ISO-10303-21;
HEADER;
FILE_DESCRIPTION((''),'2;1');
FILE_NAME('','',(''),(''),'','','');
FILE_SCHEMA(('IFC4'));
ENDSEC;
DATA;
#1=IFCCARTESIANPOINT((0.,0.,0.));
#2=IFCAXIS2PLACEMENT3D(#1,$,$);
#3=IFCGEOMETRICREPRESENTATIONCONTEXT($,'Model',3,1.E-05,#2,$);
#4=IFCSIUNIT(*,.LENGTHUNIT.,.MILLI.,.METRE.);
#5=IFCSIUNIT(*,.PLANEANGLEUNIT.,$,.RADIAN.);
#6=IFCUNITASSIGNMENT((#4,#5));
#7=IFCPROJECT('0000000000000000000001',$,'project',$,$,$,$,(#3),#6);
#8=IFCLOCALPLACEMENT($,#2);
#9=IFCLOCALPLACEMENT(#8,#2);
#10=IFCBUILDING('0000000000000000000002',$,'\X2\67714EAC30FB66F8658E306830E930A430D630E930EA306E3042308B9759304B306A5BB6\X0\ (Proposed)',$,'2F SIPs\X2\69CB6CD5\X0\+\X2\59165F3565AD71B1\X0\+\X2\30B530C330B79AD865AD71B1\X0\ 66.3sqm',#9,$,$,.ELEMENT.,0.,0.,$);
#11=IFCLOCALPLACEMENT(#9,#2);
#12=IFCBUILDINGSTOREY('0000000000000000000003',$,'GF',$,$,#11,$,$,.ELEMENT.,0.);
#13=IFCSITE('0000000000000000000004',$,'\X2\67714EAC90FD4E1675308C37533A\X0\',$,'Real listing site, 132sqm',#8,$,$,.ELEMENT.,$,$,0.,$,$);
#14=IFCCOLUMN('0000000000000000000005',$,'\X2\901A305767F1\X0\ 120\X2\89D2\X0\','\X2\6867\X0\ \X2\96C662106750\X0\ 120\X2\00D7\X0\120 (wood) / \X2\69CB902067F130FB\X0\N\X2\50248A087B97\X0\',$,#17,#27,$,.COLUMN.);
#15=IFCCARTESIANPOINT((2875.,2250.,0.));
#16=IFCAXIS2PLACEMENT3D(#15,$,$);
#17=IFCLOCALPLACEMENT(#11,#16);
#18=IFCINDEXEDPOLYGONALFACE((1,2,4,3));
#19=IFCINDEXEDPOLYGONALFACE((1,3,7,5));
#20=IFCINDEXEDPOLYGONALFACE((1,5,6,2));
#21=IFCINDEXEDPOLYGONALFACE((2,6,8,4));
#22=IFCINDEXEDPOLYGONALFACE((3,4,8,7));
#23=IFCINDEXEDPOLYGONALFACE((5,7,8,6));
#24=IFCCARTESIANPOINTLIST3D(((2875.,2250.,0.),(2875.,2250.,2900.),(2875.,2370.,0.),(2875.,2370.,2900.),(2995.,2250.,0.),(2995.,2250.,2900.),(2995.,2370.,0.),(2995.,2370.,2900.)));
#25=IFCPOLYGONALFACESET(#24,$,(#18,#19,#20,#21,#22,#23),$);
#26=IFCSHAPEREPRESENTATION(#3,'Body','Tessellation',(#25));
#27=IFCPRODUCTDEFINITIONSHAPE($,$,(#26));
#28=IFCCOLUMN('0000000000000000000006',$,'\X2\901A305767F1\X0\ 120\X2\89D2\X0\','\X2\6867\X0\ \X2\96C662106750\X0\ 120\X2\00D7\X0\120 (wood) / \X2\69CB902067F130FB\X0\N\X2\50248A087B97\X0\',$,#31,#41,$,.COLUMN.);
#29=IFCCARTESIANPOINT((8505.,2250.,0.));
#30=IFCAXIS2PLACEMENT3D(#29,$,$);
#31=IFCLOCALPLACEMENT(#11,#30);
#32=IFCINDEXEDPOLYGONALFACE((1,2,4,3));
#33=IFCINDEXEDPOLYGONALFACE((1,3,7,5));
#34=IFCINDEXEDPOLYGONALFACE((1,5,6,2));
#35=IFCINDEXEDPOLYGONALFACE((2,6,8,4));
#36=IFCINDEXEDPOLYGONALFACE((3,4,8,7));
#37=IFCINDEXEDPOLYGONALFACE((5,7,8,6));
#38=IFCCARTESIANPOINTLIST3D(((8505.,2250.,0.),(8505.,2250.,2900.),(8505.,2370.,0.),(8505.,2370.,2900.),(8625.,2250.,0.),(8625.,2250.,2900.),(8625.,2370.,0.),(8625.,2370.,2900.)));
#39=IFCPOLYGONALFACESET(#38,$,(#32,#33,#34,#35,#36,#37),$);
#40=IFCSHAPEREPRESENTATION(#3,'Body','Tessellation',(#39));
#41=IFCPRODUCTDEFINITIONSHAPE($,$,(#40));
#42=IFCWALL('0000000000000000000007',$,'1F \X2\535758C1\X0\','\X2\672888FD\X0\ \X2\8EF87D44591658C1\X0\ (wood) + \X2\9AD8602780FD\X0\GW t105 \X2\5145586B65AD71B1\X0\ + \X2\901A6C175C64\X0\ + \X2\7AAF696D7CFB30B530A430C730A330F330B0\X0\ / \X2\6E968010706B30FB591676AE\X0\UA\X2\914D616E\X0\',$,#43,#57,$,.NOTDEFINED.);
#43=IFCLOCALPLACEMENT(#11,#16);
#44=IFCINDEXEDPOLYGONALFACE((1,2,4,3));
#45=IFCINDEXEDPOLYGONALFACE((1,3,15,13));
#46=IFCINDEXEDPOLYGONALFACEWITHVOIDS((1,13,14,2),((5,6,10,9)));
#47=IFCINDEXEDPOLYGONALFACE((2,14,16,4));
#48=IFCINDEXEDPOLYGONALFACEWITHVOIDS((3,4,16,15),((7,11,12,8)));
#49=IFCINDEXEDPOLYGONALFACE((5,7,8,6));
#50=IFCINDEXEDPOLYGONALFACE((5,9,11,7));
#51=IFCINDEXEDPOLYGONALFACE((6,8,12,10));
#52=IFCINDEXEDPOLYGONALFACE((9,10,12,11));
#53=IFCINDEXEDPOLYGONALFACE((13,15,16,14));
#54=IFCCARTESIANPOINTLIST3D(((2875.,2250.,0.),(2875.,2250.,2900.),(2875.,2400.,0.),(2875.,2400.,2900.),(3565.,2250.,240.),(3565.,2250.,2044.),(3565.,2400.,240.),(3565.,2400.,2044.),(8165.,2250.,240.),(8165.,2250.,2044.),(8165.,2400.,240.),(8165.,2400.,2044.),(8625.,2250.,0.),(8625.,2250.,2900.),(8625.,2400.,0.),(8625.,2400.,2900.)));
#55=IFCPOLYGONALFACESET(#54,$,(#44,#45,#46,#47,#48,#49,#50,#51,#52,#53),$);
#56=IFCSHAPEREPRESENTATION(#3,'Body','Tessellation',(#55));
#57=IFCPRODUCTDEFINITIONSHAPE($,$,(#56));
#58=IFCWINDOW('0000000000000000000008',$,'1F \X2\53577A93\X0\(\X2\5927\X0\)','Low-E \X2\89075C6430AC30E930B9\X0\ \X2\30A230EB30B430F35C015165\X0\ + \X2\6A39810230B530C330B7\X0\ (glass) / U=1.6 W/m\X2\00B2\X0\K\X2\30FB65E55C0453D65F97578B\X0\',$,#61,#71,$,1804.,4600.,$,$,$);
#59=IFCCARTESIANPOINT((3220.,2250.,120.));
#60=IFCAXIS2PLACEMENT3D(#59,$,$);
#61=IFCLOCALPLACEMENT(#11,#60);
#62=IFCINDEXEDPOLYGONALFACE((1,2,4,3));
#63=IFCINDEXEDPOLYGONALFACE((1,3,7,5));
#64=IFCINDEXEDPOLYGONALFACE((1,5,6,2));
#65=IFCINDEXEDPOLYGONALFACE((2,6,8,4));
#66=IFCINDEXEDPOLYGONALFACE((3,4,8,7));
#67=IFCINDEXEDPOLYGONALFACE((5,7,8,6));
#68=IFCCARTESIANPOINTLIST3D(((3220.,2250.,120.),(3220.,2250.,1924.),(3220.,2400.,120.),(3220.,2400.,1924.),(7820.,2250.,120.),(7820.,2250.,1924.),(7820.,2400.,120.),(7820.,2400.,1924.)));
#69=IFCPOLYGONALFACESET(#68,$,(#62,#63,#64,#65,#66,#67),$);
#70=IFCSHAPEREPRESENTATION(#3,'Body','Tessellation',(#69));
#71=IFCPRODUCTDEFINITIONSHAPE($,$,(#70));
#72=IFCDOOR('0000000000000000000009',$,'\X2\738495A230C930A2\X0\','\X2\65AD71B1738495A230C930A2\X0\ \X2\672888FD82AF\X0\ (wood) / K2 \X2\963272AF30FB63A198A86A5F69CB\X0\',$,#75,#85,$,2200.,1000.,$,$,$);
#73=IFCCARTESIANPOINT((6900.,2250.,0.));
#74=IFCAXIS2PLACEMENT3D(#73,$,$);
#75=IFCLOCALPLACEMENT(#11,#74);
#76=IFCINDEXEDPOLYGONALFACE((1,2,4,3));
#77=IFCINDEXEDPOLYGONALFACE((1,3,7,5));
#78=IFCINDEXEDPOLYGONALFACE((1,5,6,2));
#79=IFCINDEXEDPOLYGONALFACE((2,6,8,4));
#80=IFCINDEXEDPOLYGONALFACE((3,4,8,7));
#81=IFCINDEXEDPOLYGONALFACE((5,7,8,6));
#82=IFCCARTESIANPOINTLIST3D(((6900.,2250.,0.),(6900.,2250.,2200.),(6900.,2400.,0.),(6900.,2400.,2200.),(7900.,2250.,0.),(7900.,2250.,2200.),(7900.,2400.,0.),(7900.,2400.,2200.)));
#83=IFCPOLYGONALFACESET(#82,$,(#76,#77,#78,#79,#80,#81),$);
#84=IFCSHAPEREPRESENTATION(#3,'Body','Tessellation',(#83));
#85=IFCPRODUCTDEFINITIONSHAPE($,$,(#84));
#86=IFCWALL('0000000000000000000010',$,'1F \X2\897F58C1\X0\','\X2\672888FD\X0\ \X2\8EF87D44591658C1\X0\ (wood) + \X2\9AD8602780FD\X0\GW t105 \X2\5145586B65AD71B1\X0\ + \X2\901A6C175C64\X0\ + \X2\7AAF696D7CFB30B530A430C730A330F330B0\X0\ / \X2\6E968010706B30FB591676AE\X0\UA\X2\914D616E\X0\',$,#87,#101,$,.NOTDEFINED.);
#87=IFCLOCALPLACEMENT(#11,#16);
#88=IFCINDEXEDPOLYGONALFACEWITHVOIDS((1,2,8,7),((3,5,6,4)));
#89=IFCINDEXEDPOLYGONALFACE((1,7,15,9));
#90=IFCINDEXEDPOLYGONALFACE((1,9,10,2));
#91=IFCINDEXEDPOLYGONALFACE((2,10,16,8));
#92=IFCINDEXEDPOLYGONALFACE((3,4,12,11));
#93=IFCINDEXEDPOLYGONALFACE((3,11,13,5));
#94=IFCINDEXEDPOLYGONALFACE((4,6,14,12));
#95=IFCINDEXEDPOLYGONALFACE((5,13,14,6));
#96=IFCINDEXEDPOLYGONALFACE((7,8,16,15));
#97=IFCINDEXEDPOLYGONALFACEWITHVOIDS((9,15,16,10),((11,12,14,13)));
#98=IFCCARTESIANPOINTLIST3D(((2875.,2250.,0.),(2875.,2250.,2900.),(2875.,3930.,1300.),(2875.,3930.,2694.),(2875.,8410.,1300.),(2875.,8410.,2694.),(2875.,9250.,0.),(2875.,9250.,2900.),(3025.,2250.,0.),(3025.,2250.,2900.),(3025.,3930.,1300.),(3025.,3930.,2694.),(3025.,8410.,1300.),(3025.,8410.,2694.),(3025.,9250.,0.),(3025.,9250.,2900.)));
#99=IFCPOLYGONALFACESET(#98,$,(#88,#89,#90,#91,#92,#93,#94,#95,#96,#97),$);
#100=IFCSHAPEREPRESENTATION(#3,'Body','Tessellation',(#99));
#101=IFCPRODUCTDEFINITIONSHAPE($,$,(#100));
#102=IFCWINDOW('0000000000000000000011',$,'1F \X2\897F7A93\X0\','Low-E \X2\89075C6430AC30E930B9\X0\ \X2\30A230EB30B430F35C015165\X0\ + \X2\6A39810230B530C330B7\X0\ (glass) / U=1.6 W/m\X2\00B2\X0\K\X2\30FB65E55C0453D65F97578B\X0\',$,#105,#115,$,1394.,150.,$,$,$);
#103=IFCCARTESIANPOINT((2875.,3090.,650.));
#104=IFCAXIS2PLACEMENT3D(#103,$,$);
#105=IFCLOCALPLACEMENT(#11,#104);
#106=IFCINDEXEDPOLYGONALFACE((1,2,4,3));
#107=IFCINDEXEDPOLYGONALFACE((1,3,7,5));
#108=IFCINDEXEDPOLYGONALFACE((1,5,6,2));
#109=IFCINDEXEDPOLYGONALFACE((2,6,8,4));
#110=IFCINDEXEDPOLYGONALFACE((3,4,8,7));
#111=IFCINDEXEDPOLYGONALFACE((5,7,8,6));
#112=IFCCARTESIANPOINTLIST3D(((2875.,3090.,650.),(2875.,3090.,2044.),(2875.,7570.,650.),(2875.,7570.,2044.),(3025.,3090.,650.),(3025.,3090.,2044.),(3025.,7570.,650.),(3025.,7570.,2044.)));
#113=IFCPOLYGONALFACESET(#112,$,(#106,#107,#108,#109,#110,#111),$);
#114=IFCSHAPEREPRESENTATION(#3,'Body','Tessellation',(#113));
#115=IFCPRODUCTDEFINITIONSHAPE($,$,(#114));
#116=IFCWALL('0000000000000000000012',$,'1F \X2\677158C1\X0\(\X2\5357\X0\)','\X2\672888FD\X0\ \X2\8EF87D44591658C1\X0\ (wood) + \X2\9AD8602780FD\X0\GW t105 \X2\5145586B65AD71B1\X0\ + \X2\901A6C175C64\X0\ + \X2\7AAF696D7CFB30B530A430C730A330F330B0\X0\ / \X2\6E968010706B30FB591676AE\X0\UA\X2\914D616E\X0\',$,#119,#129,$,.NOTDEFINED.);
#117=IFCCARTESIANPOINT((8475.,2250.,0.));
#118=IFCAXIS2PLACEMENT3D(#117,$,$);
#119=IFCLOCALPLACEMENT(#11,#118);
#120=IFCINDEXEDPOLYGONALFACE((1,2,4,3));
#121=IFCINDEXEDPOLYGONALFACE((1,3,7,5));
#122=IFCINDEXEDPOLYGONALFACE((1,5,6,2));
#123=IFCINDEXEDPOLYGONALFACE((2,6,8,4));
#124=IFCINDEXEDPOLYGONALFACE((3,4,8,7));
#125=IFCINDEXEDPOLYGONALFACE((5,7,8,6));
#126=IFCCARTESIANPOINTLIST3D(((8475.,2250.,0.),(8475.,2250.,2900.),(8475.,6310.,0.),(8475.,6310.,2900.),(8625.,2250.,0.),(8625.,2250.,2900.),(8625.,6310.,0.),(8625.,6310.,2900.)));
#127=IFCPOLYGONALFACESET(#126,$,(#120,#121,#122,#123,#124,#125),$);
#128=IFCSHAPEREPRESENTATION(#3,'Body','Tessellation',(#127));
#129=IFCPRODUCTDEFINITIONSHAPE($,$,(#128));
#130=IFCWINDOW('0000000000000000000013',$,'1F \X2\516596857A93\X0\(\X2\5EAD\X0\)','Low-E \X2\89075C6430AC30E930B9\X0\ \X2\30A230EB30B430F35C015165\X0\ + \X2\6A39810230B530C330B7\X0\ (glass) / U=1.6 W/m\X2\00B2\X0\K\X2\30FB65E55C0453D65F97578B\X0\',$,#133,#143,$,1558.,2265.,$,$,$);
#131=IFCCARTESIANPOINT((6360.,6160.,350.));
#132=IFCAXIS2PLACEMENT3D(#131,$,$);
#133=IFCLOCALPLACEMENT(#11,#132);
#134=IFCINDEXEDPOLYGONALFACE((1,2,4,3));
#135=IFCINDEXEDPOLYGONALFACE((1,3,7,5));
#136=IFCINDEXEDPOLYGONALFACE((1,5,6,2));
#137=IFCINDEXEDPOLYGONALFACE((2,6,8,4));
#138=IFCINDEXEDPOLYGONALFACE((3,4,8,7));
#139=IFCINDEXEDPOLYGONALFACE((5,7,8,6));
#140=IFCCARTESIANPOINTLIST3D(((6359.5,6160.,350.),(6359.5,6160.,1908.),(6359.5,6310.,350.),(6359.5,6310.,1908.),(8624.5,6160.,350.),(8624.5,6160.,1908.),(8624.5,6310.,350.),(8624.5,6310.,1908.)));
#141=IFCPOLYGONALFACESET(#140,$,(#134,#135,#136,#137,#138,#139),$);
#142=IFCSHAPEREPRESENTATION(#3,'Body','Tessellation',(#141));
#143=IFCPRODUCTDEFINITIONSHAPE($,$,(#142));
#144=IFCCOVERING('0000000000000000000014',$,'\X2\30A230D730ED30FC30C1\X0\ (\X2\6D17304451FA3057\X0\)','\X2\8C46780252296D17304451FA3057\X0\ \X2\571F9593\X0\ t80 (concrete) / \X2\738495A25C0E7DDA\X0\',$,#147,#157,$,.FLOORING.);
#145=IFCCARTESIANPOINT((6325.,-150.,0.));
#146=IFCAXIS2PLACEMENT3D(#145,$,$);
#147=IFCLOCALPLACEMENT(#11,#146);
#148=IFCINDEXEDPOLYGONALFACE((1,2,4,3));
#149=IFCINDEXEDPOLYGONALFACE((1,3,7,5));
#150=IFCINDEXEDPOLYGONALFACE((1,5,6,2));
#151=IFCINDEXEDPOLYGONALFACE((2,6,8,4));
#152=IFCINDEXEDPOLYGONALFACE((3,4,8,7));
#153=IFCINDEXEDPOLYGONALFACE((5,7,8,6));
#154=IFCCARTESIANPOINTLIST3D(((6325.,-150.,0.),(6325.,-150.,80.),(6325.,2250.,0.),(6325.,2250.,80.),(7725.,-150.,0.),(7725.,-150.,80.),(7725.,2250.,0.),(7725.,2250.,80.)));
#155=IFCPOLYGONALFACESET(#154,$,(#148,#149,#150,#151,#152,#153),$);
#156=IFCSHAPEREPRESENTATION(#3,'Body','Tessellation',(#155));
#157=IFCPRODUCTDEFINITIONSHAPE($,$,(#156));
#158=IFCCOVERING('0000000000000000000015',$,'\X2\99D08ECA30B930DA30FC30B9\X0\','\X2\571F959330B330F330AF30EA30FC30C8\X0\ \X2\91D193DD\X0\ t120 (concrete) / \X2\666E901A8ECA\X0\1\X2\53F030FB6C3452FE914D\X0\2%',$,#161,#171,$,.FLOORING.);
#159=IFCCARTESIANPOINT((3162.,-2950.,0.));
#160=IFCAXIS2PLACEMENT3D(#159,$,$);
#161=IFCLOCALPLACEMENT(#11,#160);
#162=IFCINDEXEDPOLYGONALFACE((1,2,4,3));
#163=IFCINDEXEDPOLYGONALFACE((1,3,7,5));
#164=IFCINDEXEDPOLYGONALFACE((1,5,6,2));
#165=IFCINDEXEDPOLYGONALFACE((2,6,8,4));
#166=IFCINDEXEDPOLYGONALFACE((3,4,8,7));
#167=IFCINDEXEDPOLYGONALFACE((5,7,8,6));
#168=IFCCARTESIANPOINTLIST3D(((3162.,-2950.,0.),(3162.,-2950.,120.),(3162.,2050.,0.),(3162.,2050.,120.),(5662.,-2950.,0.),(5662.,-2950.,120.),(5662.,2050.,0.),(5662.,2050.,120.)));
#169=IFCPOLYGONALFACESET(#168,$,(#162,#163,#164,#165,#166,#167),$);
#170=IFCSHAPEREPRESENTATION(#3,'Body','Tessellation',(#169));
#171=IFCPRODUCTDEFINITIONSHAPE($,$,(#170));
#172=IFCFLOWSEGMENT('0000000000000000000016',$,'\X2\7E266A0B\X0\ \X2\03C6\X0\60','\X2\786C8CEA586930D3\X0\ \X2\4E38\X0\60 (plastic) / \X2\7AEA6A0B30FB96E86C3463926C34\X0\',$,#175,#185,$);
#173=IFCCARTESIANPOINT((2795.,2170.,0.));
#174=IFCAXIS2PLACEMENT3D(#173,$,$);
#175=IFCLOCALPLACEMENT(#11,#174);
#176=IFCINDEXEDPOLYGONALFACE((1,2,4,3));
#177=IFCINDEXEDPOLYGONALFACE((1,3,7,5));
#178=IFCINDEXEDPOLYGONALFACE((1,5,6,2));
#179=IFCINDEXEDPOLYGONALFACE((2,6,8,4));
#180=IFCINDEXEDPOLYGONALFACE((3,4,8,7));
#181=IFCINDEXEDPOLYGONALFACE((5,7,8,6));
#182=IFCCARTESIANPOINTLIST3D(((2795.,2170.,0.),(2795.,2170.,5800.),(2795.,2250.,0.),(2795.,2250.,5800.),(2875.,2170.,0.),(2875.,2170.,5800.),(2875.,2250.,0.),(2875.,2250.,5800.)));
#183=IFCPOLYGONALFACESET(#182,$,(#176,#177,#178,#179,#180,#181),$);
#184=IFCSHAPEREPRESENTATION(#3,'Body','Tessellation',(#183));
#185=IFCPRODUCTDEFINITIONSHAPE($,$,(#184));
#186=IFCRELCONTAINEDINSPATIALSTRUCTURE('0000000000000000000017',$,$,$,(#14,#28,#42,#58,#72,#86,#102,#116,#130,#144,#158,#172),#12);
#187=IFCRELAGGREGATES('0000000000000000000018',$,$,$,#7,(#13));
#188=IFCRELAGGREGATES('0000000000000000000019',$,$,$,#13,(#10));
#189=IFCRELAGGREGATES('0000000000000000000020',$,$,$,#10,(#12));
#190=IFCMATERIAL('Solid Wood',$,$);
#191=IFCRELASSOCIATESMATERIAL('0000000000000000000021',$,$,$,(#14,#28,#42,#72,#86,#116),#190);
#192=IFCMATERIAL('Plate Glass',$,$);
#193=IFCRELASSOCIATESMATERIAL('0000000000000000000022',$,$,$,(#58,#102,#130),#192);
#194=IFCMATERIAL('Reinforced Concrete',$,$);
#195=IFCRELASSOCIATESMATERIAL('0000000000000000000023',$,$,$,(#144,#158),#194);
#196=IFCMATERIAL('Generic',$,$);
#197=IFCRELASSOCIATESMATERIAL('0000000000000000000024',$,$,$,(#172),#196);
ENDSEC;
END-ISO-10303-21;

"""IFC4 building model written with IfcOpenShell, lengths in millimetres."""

from ifc_helpers import new_model, si_unit, frame, frame_2d, origin, place, context, project, spatial, rectangle, extrude, material, element, fill, save


model = new_model("IFC4")

# Units and contexts
model_context = context("Model", 3, precision=1e-05, world=origin())
ifc_project = project(units=[si_unit("LENGTHUNIT", "METRE", prefix="MILLI"), si_unit("PLANEANGLEUNIT", "RADIAN")], contexts=[model_context])

# Site, building, storey
site_placement = place(None, origin())
site = spatial("IfcSite", under=ifc_project, at=site_placement, Name="東京都世田谷区", ObjectType="Real listing site, 132sqm", CompositionType="ELEMENT", RefElevation=0.0)
building_placement = place(site_placement, origin())
building = spatial("IfcBuilding", under=site, at=building_placement, Name="東京・書斎とライブラリのある静かな家 (Proposed)", ObjectType="2F SIPs構法+外張断熱+サッシ高断熱 66.3sqm", CompositionType="ELEMENT", ElevationOfRefHeight=0.0, ElevationOfTerrain=0.0)
storey_placement = place(building_placement, origin())
storey = spatial("IfcBuildingStorey", under=building, at=storey_placement, Name="GF", CompositionType="ELEMENT", Elevation=0.0)

# Columns
ifc_material_1 = material(Name="Solid Wood")
column_1_placement = place(storey_placement, frame((2875.0, 2250.0, 0.0)))
element("IfcColumn", 1, at=column_1_placement, inside=storey, material=ifc_material_1, Name="通し柱 120角", Description="桧 集成材 120×120 (wood) / 構造柱・N値計算", PredefinedType="COLUMN", context=model_context, shape_type="SweptSolid", body=[
    extrude(rectangle(XDim=120.0, YDim=120.0, at=frame_2d((60.0, 60.0))), frame((2875.0, 2250.0, 0.0)), (0.0, 0.0, 1.0), 2900.0),
])
column_2_placement = place(storey_placement, frame((8505.0, 2250.0, 0.0)))
element("IfcColumn", 2, at=column_2_placement, inside=storey, material=ifc_material_1, Name="通し柱 120角", Description="桧 集成材 120×120 (wood) / 構造柱・N値計算", PredefinedType="COLUMN", context=model_context, shape_type="SweptSolid", body=[
    extrude(rectangle(XDim=120.0, YDim=120.0, at=frame_2d((60.0, 60.0))), frame((8505.0, 2250.0, 0.0)), (0.0, 0.0, 1.0), 2900.0),
])

# Shared definitions
ifc_material_2 = material(Name="Reinforced Concrete")

# Wall, openings, window, door
wall_1_placement = place(storey_placement, frame((2875.0, 2250.0, 0.0)))
wall_1 = element("IfcWall", 3, at=wall_1_placement, inside=storey, material=ifc_material_1, Name="1F 南壁", Description="木製 軸組外壁 (wood) + 高性能GW t105 充填断熱 + 通気層 + 窯業系サイディング / 準耐火・外皮UA配慮", PredefinedType="NOTDEFINED", context=model_context, shape_type="SweptSolid", body=[
    extrude(rectangle(XDim=5750.0, YDim=150.0, at=frame_2d((2875.0, 75.0))), frame((2875.0, 2250.0, 0.0)), (0.0, 0.0, 1.0), 2900.0),
])
opening_1_placement = place(storey_placement, frame((3220.0, 2250.0, 120.0)))
opening_1 = element("IfcOpeningElement", 4, at=opening_1_placement, cuts=wall_1, PredefinedType="NOTDEFINED", context=model_context, shape_type="SweptSolid", body=[
    extrude(rectangle(XDim=4600.0, YDim=150.0, at=frame_2d((2300.0, 75.0))), frame((3220.0, 2250.0, 120.0)), (0.0, 0.0, 1.0), 1804.0),
])
opening_2_placement = place(storey_placement, frame((6900.0, 2250.0, 0.0)))
opening_2 = element("IfcOpeningElement", 5, at=opening_2_placement, cuts=wall_1, PredefinedType="NOTDEFINED", context=model_context, shape_type="SweptSolid", body=[
    extrude(rectangle(XDim=1000.0, YDim=150.0, at=frame_2d((500.0, 75.0))), frame((6900.0, 2250.0, 0.0)), (0.0, 0.0, 1.0), 2200.0),
])
ifc_material_3 = material(Name="Plate Glass")
window_1_placement = place(storey_placement, frame((3220.0, 2250.0, 120.0)))
window_1 = element("IfcWindow", 6, at=window_1_placement, inside=storey, material=ifc_material_3, Name="1F 南窓(大)", Description="Low-E 複層ガラス アルゴン封入 + 樹脂サッシ (glass) / U=1.6 W/m²K・日射取得型", OverallHeight=1804.0, OverallWidth=4600.0, context=model_context, shape_type="SweptSolid", body=[
    extrude(rectangle(XDim=4600.0, YDim=150.0, at=frame_2d((2300.0, 75.0))), frame((3220.0, 2250.0, 120.0)), (0.0, 0.0, 1.0), 1804.0),
])
fill(opening_1, window_1)
door_1_placement = place(storey_placement, frame((6900.0, 2250.0, 0.0)))
door_1 = element("IfcDoor", 7, at=door_1_placement, inside=storey, material=ifc_material_1, Name="玄関ドア", Description="断熱玄関ドア 木製芯 (wood) / K2 防犯・採風機構", OverallHeight=2200.0, OverallWidth=1000.0, context=model_context, shape_type="SweptSolid", body=[
    extrude(rectangle(XDim=1000.0, YDim=150.0, at=frame_2d((500.0, 75.0))), frame((6900.0, 2250.0, 0.0)), (0.0, 0.0, 1.0), 2200.0),
])
fill(opening_2, door_1)

# Walls, openings, windows
wall_2_placement = place(storey_placement, frame((2875.0, 2250.0, 0.0)))
wall_2 = element("IfcWall", 8, at=wall_2_placement, inside=storey, material=ifc_material_1, Name="1F 西壁", Description="木製 軸組外壁 (wood) + 高性能GW t105 充填断熱 + 通気層 + 窯業系サイディング / 準耐火・外皮UA配慮", PredefinedType="NOTDEFINED", context=model_context, shape_type="SweptSolid", body=[
    extrude(rectangle(XDim=150.0, YDim=7000.0, at=frame_2d((75.0, 3500.0))), frame((2875.0, 2250.0, 0.0)), (0.0, 0.0, 1.0), 2900.0),
])
opening_3_placement = place(storey_placement, frame((2875.0, 3090.0, 650.0)))
opening_3 = element("IfcOpeningElement", 9, at=opening_3_placement, cuts=wall_2, PredefinedType="NOTDEFINED", context=model_context, shape_type="SweptSolid", body=[
    extrude(rectangle(XDim=150.0, YDim=4480.0, at=frame_2d((75.0, 2240.0))), frame((2875.0, 3090.0, 650.0)), (0.0, 0.0, 1.0), 1394.0),
])
window_2_placement = place(storey_placement, frame((2875.0, 3090.0, 650.0)))
window_2 = element("IfcWindow", 10, at=window_2_placement, inside=storey, material=ifc_material_3, Name="1F 西窓", Description="Low-E 複層ガラス アルゴン封入 + 樹脂サッシ (glass) / U=1.6 W/m²K・日射取得型", OverallHeight=1394.0, OverallWidth=150.0, context=model_context, shape_type="SweptSolid", body=[
    extrude(rectangle(XDim=150.0, YDim=4480.0, at=frame_2d((75.0, 2240.0))), frame((2875.0, 3090.0, 650.0)), (0.0, 0.0, 1.0), 1394.0),
])
fill(opening_3, window_2)
wall_3_placement = place(storey_placement, frame((8475.0, 2250.0, 0.0)))
wall_3 = element("IfcWall", 11, at=wall_3_placement, inside=storey, material=ifc_material_1, Name="1F 東壁(南)", Description="木製 軸組外壁 (wood) + 高性能GW t105 充填断熱 + 通気層 + 窯業系サイディング / 準耐火・外皮UA配慮", PredefinedType="NOTDEFINED", context=model_context, shape_type="SweptSolid", body=[
    extrude(rectangle(XDim=150.0, YDim=4060.0, at=frame_2d((75.0, 2030.0))), frame((8475.0, 2250.0, 0.0)), (0.0, 0.0, 1.0), 2900.0),
])
opening_4_placement = place(storey_placement, frame((6360.0, 6160.0, 350.0)))
opening_4 = element("IfcOpeningElement", 12, at=opening_4_placement, cuts=wall_3, PredefinedType="NOTDEFINED", context=model_context, shape_type="SweptSolid", body=[
    extrude(rectangle(XDim=2265.0, YDim=150.0, at=frame_2d((1132.0, 75.0))), frame((6360.0, 6160.0, 350.0)), (0.0, 0.0, 1.0), 1558.0),
])
window_3_placement = place(storey_placement, frame((6360.0, 6160.0, 350.0)))
window_3 = element("IfcWindow", 13, at=window_3_placement, inside=storey, material=ifc_material_3, Name="1F 入隅窓(庭)", Description="Low-E 複層ガラス アルゴン封入 + 樹脂サッシ (glass) / U=1.6 W/m²K・日射取得型", OverallHeight=1558.0, OverallWidth=2265.0, context=model_context, shape_type="SweptSolid", body=[
    extrude(rectangle(XDim=2265.0, YDim=150.0, at=frame_2d((1132.0, 75.0))), frame((6360.0, 6160.0, 350.0)), (0.0, 0.0, 1.0), 1558.0),
])
fill(opening_4, window_3)

# Coverings
covering_1_placement = place(storey_placement, frame((6325.0, -150.0, 0.0)))
element("IfcCovering", 14, at=covering_1_placement, inside=storey, material=ifc_material_2, Name="アプローチ (洗い出し)", Description="豆砂利洗い出し 土間 t80 (concrete) / 玄関導線", PredefinedType="FLOORING", context=model_context, shape_type="SweptSolid", body=[
    extrude(rectangle(XDim=1400.0, YDim=2400.0, at=frame_2d((700.0, 1200.0))), frame((6325.0, -150.0, 0.0)), (0.0, 0.0, 1.0), 80.0),
])
covering_2_placement = place(storey_placement, frame((3162.0, -2950.0, 0.0)))
element("IfcCovering", 15, at=covering_2_placement, inside=storey, material=ifc_material_2, Name="駐車スペース", Description="土間コンクリート 金鏝 t120 (concrete) / 普通車1台・水勾配2%", PredefinedType="FLOORING", context=model_context, shape_type="SweptSolid", body=[
    extrude(rectangle(XDim=2500.0, YDim=5000.0, at=frame_2d((1250.0, 2500.0))), frame((3162.0, -2950.0, 0.0)), (0.0, 0.0, 1.0), 120.0),
])

# Flow segment
ifc_material_4 = material(Name="Generic")
flow_segment_1_placement = place(storey_placement, frame((2795.0, 2170.0, 0.0)))
element("IfcFlowSegment", 16, at=flow_segment_1_placement, inside=storey, material=ifc_material_4, Name="縦樋 φ60", Description="硬質塩ビ 丸60 (plastic) / 竪樋・雨水排水", context=model_context, shape_type="SweptSolid", body=[
    extrude(rectangle(XDim=80.0, YDim=80.0, at=frame_2d((40.0, 40.0))), frame((2795.0, 2170.0, 0.0)), (0.0, 0.0, 1.0), 5800.0),
])

save(model, "model.ifc")
